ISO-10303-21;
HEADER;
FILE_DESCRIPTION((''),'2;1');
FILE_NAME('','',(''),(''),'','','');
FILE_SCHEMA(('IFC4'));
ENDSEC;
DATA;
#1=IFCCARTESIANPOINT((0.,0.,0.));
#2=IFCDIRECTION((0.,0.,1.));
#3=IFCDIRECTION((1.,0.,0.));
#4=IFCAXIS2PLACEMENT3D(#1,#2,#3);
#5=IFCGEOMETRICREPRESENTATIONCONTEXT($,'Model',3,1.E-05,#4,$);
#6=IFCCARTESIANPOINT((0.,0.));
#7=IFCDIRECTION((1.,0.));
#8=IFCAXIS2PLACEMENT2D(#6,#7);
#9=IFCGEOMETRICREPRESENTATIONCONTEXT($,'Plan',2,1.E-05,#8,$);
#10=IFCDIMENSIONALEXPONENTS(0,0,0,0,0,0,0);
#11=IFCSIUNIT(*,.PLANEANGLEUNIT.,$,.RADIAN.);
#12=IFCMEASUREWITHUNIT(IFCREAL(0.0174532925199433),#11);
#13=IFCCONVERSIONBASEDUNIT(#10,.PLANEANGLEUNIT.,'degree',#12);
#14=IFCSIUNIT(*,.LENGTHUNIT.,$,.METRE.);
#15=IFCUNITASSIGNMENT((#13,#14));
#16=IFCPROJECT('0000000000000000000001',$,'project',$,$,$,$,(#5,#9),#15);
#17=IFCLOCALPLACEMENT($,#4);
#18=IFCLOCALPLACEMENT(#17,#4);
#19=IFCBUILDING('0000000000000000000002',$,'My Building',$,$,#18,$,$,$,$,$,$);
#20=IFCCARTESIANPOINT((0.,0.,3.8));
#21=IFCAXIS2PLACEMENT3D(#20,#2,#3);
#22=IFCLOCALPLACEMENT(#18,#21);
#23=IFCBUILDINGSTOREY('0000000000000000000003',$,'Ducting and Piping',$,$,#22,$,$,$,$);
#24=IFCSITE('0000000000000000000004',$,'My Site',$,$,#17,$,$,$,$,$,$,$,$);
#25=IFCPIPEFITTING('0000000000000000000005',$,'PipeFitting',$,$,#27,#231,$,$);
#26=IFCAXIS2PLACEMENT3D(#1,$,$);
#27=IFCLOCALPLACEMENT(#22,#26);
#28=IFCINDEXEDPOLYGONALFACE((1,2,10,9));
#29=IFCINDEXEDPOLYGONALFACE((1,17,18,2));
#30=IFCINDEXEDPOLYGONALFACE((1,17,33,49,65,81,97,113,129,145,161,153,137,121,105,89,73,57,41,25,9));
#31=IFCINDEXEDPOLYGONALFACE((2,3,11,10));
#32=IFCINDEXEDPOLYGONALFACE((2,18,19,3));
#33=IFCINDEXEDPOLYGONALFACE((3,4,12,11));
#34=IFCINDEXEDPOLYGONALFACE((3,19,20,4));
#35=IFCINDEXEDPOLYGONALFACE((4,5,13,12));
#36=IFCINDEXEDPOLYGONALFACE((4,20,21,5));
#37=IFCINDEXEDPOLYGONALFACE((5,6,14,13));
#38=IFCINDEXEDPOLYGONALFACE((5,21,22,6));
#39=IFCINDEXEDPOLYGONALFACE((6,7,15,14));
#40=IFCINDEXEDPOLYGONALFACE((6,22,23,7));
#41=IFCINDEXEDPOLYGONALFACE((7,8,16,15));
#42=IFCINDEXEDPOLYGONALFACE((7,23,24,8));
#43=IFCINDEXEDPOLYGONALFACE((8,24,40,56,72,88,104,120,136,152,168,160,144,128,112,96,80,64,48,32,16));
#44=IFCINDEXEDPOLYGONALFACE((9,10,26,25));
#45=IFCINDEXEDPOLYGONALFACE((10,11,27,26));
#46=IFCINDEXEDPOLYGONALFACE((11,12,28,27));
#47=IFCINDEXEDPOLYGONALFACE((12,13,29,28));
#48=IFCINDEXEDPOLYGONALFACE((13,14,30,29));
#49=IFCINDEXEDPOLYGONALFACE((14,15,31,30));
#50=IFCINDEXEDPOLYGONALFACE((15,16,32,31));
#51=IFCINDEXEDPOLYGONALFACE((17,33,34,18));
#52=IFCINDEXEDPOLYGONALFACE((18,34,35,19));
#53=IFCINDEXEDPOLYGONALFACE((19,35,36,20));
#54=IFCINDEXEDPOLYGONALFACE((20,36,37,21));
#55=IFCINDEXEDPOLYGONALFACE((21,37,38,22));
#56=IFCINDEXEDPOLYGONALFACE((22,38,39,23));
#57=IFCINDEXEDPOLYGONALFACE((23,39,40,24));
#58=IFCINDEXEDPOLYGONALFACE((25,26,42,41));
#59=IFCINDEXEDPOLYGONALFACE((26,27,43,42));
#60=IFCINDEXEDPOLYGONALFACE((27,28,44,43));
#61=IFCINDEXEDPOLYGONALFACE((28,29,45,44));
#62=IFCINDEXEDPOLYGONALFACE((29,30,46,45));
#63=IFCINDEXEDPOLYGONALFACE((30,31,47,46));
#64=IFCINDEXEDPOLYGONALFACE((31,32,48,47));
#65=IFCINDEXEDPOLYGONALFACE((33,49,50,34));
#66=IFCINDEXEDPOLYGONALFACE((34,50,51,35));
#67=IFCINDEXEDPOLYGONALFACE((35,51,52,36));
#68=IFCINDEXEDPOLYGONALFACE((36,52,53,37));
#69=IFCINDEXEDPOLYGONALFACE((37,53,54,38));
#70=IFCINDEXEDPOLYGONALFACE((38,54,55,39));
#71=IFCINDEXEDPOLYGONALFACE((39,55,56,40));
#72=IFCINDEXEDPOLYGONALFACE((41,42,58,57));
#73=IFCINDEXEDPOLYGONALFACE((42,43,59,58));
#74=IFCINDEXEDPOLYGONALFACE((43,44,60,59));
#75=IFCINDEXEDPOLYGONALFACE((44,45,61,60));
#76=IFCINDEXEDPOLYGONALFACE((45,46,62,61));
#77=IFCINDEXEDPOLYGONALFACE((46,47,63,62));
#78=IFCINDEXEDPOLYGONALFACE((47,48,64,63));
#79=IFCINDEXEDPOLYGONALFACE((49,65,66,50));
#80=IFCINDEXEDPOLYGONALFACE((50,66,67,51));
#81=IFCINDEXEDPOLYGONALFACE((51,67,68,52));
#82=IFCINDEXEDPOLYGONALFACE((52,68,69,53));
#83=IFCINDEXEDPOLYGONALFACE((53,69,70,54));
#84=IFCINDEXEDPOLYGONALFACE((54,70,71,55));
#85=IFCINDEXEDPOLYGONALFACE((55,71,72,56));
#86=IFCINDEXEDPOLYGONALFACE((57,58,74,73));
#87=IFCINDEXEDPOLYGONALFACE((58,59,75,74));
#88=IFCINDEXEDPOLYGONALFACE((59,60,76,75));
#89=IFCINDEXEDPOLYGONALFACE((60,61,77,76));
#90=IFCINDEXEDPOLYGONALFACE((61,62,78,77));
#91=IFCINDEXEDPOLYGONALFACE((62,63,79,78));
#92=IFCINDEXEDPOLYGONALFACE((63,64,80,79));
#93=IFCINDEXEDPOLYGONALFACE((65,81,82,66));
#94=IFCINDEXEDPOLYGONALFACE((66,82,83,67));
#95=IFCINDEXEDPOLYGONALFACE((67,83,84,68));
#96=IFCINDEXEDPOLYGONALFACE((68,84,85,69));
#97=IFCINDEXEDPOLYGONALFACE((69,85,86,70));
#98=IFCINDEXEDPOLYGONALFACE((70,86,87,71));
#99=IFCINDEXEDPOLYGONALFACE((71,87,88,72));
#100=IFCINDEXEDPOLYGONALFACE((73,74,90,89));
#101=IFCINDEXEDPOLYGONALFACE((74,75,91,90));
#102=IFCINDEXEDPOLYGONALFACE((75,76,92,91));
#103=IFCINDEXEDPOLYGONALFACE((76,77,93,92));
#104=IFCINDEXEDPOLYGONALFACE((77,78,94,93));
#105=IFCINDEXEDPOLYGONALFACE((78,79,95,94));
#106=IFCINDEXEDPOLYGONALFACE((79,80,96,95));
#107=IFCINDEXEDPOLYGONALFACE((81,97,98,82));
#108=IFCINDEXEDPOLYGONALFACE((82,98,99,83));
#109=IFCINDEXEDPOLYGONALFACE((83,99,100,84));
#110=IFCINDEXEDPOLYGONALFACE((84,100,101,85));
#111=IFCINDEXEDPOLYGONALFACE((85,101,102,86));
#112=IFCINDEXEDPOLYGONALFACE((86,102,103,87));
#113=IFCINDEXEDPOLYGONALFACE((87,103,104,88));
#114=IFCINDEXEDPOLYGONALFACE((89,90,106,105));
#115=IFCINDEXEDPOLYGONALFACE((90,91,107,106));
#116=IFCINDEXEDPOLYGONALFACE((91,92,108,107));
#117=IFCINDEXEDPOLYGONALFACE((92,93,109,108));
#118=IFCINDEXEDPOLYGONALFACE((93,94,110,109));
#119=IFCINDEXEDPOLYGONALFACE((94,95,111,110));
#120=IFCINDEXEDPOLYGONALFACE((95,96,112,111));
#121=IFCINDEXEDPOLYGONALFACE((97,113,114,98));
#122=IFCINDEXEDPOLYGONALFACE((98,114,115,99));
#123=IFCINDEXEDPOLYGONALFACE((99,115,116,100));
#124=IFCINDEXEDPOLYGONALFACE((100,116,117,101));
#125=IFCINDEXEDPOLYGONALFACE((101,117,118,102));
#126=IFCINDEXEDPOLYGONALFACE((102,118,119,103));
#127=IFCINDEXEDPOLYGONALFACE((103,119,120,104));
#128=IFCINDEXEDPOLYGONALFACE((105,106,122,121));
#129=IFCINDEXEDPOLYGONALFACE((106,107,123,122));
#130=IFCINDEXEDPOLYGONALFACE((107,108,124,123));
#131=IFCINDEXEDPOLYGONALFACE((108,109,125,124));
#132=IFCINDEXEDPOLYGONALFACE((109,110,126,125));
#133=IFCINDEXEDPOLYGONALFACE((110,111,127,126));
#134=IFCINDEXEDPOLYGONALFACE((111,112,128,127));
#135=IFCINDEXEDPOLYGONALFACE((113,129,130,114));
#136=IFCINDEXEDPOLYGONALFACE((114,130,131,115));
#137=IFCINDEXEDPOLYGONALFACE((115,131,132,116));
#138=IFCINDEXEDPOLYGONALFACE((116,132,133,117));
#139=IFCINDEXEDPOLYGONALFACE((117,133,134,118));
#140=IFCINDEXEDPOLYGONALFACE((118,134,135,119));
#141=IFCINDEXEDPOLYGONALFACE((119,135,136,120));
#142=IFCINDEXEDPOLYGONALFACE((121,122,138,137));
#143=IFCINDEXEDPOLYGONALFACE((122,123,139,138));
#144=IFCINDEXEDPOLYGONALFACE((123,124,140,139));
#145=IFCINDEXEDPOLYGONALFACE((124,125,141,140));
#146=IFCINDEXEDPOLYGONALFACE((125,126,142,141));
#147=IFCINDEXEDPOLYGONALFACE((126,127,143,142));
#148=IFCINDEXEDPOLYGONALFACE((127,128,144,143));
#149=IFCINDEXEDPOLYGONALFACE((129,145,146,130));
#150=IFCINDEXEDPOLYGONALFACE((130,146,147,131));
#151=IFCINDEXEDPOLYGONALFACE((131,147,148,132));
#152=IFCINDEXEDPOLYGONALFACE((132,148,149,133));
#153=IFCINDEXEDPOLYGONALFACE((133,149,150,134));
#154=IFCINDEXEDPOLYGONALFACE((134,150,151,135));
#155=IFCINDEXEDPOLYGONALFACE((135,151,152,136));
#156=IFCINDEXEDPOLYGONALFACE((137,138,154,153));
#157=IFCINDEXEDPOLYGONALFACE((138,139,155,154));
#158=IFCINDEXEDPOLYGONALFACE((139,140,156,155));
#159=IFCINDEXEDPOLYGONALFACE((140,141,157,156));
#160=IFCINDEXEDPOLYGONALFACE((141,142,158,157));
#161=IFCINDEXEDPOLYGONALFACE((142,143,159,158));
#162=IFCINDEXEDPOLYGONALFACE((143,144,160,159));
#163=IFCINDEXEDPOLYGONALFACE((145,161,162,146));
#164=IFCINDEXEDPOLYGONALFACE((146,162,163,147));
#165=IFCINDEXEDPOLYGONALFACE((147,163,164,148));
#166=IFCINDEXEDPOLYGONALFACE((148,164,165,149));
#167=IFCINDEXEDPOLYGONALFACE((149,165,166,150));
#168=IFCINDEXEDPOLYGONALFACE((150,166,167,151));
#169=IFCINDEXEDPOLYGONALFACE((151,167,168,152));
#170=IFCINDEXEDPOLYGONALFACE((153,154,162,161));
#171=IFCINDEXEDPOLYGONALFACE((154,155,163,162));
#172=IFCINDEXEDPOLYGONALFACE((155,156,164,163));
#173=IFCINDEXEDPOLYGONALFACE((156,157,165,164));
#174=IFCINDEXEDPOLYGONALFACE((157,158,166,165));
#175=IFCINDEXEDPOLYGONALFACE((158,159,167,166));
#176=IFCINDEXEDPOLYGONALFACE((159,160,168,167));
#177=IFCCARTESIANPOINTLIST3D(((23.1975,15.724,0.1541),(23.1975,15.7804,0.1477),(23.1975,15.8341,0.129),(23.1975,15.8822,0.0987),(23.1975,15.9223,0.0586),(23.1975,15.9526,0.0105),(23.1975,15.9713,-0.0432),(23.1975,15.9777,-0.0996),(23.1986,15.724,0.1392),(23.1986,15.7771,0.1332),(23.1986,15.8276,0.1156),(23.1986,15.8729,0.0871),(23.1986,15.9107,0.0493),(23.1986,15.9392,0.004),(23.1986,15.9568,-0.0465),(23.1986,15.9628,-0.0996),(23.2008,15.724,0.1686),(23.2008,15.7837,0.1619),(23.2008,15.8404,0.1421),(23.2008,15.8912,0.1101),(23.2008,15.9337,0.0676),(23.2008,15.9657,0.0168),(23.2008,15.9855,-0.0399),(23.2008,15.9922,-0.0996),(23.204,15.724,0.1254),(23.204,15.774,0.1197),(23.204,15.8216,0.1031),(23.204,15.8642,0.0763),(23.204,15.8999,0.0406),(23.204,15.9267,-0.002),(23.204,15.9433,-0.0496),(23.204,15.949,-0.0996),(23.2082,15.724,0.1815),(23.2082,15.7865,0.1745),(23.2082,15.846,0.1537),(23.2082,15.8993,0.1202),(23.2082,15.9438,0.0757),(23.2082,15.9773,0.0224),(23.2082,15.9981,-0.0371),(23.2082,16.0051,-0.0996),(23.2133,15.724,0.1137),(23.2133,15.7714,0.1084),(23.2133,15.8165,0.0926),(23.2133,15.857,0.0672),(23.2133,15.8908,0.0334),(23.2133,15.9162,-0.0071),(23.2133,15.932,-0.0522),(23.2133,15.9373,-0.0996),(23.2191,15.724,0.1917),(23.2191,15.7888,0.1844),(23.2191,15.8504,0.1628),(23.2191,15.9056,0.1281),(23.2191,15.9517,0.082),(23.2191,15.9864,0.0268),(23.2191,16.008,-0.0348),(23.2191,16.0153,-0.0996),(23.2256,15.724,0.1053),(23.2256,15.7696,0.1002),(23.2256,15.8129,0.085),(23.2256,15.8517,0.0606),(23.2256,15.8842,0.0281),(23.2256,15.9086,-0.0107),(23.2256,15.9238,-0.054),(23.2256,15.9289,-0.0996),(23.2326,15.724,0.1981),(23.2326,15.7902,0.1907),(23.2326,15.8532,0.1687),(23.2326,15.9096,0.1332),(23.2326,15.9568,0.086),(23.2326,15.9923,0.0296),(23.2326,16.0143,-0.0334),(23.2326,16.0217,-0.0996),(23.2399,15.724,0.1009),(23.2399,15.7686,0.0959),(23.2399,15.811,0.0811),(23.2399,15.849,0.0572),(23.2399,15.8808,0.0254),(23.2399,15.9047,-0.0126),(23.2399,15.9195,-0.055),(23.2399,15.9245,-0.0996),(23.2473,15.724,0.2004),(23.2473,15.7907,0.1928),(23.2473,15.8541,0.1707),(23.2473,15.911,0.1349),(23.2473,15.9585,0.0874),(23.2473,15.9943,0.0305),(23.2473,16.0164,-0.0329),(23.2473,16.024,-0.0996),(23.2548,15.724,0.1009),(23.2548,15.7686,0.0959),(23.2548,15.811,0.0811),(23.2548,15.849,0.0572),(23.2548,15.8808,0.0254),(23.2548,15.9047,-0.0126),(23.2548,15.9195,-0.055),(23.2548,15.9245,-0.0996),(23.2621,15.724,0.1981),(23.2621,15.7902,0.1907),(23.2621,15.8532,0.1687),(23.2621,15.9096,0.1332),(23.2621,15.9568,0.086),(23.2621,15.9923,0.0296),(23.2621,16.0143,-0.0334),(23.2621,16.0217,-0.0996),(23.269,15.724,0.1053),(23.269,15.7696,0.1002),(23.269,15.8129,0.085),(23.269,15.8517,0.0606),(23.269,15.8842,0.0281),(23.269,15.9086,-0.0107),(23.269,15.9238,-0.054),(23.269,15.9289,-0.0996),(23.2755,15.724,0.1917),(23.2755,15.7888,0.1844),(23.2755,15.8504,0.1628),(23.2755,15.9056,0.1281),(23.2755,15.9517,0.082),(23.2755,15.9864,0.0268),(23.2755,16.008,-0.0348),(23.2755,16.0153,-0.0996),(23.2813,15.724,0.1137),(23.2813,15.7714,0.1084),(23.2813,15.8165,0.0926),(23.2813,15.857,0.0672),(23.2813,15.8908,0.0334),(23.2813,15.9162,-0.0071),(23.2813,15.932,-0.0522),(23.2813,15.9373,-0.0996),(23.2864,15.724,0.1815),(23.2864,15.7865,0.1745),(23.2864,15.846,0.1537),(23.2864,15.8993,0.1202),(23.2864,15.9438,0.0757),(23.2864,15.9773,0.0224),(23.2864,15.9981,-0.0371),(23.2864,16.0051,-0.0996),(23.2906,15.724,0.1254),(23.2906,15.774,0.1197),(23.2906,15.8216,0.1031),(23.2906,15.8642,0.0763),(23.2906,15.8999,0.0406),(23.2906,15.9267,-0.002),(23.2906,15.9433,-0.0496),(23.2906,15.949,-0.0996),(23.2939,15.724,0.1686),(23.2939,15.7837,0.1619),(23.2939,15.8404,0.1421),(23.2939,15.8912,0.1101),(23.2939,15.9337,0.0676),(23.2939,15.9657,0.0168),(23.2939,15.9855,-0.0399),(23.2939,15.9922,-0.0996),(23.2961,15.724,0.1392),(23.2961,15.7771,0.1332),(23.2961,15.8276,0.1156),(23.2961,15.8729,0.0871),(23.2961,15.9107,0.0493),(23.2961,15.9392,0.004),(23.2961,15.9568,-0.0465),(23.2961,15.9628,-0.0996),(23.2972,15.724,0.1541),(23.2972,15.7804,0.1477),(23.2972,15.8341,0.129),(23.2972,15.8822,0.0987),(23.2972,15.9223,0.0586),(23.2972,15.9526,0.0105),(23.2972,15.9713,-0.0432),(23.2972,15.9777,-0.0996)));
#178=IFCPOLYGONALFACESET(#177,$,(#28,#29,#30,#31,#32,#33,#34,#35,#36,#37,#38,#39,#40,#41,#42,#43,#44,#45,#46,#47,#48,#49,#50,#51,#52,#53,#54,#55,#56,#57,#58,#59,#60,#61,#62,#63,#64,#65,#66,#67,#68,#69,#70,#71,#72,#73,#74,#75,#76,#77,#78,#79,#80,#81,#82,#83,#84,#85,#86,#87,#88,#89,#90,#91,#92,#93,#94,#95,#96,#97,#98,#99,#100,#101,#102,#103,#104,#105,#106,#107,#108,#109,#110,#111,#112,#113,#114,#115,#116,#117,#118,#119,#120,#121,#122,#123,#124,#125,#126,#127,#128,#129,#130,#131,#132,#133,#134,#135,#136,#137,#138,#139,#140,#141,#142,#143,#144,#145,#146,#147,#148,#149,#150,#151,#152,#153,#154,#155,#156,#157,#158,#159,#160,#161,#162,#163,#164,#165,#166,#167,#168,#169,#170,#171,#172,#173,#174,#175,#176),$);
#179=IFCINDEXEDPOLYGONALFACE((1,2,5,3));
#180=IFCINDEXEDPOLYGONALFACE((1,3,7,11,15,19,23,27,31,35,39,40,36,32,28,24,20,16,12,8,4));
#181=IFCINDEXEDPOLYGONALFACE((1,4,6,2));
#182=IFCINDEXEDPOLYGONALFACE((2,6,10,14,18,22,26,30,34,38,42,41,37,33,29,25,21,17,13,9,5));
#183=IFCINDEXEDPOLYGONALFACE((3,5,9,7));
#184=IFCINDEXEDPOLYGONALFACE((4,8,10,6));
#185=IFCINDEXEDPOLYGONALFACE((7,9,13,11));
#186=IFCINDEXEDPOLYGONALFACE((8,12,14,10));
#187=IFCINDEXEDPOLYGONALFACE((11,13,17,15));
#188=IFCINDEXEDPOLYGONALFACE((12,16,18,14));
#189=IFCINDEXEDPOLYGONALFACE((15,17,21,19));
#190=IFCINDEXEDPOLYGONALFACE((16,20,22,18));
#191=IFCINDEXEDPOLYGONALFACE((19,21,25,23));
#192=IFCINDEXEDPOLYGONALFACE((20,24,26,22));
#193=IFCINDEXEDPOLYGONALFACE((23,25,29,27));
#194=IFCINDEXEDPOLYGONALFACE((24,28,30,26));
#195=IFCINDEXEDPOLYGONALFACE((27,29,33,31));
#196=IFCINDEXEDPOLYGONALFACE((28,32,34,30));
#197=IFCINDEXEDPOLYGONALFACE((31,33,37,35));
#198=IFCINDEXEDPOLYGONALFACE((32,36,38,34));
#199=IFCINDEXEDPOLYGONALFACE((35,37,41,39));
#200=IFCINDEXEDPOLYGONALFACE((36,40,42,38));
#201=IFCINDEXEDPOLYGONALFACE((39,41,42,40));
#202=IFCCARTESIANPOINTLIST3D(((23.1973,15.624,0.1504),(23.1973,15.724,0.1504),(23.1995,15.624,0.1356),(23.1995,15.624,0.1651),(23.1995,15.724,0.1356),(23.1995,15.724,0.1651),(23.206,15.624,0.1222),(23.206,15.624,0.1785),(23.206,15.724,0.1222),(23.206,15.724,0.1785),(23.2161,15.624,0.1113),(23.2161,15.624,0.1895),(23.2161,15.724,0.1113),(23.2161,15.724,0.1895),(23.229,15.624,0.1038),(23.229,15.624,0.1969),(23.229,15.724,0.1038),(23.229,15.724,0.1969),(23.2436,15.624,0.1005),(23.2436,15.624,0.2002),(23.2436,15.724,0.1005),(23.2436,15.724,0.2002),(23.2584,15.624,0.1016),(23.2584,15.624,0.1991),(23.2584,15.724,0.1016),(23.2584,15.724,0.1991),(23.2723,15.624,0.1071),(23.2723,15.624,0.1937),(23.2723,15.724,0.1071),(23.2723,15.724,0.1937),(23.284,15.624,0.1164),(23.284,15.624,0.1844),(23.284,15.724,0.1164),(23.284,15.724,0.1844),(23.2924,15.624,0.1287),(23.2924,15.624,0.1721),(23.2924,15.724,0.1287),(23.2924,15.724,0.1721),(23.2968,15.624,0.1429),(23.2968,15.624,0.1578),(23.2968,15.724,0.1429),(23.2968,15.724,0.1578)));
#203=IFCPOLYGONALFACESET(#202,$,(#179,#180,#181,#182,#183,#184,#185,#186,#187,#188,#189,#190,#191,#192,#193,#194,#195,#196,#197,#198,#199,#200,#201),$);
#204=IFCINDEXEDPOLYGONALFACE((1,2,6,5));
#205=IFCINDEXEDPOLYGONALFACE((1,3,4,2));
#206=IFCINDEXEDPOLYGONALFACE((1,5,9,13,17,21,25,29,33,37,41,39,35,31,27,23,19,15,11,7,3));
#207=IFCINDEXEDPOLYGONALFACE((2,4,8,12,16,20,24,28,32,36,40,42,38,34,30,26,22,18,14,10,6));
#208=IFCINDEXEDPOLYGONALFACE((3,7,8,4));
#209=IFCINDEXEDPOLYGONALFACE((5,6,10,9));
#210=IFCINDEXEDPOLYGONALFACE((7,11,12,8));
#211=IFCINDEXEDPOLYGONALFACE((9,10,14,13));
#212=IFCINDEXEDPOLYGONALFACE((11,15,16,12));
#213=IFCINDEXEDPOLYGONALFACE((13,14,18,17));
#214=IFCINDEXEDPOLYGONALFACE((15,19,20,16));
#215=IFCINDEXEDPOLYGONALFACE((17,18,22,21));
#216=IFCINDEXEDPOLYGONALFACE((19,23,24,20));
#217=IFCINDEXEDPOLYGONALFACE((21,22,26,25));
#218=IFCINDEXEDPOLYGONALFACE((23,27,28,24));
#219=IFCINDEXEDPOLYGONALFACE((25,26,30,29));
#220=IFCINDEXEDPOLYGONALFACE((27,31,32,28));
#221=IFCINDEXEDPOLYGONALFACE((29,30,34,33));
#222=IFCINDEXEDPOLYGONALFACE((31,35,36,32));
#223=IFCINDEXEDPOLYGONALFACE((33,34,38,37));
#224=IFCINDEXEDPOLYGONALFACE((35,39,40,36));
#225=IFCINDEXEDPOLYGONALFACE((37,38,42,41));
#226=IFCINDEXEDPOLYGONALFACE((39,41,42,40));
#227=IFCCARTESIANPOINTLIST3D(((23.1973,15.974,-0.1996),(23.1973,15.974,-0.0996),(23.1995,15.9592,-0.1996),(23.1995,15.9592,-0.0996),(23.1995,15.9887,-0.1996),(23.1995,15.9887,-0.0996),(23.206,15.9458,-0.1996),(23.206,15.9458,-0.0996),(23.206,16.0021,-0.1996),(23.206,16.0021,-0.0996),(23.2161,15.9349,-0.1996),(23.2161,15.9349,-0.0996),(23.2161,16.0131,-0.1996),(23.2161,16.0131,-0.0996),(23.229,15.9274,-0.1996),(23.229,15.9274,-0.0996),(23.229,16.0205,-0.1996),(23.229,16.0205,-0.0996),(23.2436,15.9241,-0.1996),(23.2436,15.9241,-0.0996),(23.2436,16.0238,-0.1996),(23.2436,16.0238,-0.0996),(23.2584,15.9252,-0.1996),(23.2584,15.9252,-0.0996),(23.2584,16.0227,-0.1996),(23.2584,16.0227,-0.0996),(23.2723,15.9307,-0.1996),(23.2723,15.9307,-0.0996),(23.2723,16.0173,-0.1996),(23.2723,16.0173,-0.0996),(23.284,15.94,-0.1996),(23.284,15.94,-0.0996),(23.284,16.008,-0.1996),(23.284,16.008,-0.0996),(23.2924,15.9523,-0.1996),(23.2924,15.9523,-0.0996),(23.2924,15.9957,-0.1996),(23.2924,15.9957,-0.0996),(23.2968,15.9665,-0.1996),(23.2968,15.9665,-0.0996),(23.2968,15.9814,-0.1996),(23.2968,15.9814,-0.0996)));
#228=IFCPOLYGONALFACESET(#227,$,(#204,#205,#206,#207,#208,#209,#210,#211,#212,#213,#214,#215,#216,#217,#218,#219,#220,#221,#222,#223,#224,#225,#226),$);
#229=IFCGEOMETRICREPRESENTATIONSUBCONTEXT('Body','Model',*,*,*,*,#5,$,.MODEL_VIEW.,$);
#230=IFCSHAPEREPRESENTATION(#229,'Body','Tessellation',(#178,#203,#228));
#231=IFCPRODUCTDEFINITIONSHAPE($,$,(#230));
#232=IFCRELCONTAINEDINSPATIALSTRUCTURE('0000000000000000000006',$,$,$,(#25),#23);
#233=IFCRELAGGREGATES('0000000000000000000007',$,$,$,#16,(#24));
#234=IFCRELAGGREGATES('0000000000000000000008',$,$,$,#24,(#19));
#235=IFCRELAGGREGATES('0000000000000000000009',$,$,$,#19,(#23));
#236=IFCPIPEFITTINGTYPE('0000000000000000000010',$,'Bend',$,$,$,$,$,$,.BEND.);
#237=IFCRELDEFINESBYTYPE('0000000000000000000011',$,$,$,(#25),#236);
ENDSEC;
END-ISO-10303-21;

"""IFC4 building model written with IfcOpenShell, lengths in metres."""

from ifc_helpers import new_model, entity, si_unit, converted_unit, frame, origin_with_axes, origin_2d_with_axis, place, context, subcontext, project, spatial, circle, extrude, source, transform, mapped, type_object, type_shapes, element, save


model = new_model("IFC4")

# Units and contexts
model_context = context("Model", 3, precision=1e-05, world=origin_with_axes())
plan_context = context("Plan", 2, precision=1e-05, world=origin_2d_with_axis())
body_context = subcontext(model_context, "Body", "Model", "MODEL_VIEW")
ifc_project = project(units=[converted_unit("PLANEANGLEUNIT", "degree", entity("IfcReal", 0.0174532925199433), si_unit("PLANEANGLEUNIT", "RADIAN"), dimensions=[0, 0, 0, 0, 0, 0, 0]), si_unit("LENGTHUNIT", "METRE")], contexts=[model_context, plan_context])

# Site, building, storey
site_placement = place(None, origin_with_axes())
site = spatial("IfcSite", under=ifc_project, at=site_placement, Name="My Site")
building_placement = place(site_placement, origin_with_axes())
building = spatial("IfcBuilding", under=site, at=building_placement, Name="My Building")
storey_placement = place(building_placement, frame((0.0, 0.0, 3.8), z_axis=(0.0, 0.0, 1.0), x_axis=(1.0, 0.0, 0.0)))
storey = spatial("IfcBuildingStorey", under=building, at=storey_placement, Name="Ducting and Piping")

# Pipe fitting
pipe_fitting_type = type_object("IfcPipeFittingType", Name="Bend", PredefinedType="BEND")
shared_shape = source(origin_with_axes(), body_context, "Body", "SolidModel", [
    entity("IfcSweptDiskSolid", entity("IfcIndexedPolyCurve", entity("IfcCartesianPointList3D", [[0.0, 0.0, 0.1], [0.0, -0.0732, 0.2768], [0.0, -0.25, 0.35]]), [entity("IfcArcIndex", [1, 2, 3])]), 0.05),
    extrude(circle(Radius=0.05), origin_with_axes(), (0.0, 0.0, 1.0), 0.1),
    extrude(circle(Radius=0.05), frame((0.0, -0.25, 0.35), z_axis=(0.0, -1.0, 0.0), x_axis=(1.0, 0.0, 0.0)), (0.0, 0.0, 1.0), 0.1),
])
type_shapes(pipe_fitting_type, [shared_shape])
for number, where, z_axis, x_axis, name in (
    (1, (23.2473, 15.624, 0.1504), (0.0, 1.0, 0.0), (-1.0, 0.0, 0.0), "PipeFitting"),
):
    element("IfcPipeFitting", number, at=place(storey_placement, frame(where, z_axis=z_axis, x_axis=x_axis)), inside=storey, type_object=pipe_fitting_type, Name=name, context=body_context, shape_type="MappedRepresentation", body=[
        mapped(shared_shape, transform((0.0, 0.0, 0.0), x_axis=(1.0, 0.0, 0.0), y_axis=(0.0, 1.0, 0.0), z_axis=(0.0, 0.0, 1.0), scale=1.0)),
    ])

save(model, "model.ifc")
